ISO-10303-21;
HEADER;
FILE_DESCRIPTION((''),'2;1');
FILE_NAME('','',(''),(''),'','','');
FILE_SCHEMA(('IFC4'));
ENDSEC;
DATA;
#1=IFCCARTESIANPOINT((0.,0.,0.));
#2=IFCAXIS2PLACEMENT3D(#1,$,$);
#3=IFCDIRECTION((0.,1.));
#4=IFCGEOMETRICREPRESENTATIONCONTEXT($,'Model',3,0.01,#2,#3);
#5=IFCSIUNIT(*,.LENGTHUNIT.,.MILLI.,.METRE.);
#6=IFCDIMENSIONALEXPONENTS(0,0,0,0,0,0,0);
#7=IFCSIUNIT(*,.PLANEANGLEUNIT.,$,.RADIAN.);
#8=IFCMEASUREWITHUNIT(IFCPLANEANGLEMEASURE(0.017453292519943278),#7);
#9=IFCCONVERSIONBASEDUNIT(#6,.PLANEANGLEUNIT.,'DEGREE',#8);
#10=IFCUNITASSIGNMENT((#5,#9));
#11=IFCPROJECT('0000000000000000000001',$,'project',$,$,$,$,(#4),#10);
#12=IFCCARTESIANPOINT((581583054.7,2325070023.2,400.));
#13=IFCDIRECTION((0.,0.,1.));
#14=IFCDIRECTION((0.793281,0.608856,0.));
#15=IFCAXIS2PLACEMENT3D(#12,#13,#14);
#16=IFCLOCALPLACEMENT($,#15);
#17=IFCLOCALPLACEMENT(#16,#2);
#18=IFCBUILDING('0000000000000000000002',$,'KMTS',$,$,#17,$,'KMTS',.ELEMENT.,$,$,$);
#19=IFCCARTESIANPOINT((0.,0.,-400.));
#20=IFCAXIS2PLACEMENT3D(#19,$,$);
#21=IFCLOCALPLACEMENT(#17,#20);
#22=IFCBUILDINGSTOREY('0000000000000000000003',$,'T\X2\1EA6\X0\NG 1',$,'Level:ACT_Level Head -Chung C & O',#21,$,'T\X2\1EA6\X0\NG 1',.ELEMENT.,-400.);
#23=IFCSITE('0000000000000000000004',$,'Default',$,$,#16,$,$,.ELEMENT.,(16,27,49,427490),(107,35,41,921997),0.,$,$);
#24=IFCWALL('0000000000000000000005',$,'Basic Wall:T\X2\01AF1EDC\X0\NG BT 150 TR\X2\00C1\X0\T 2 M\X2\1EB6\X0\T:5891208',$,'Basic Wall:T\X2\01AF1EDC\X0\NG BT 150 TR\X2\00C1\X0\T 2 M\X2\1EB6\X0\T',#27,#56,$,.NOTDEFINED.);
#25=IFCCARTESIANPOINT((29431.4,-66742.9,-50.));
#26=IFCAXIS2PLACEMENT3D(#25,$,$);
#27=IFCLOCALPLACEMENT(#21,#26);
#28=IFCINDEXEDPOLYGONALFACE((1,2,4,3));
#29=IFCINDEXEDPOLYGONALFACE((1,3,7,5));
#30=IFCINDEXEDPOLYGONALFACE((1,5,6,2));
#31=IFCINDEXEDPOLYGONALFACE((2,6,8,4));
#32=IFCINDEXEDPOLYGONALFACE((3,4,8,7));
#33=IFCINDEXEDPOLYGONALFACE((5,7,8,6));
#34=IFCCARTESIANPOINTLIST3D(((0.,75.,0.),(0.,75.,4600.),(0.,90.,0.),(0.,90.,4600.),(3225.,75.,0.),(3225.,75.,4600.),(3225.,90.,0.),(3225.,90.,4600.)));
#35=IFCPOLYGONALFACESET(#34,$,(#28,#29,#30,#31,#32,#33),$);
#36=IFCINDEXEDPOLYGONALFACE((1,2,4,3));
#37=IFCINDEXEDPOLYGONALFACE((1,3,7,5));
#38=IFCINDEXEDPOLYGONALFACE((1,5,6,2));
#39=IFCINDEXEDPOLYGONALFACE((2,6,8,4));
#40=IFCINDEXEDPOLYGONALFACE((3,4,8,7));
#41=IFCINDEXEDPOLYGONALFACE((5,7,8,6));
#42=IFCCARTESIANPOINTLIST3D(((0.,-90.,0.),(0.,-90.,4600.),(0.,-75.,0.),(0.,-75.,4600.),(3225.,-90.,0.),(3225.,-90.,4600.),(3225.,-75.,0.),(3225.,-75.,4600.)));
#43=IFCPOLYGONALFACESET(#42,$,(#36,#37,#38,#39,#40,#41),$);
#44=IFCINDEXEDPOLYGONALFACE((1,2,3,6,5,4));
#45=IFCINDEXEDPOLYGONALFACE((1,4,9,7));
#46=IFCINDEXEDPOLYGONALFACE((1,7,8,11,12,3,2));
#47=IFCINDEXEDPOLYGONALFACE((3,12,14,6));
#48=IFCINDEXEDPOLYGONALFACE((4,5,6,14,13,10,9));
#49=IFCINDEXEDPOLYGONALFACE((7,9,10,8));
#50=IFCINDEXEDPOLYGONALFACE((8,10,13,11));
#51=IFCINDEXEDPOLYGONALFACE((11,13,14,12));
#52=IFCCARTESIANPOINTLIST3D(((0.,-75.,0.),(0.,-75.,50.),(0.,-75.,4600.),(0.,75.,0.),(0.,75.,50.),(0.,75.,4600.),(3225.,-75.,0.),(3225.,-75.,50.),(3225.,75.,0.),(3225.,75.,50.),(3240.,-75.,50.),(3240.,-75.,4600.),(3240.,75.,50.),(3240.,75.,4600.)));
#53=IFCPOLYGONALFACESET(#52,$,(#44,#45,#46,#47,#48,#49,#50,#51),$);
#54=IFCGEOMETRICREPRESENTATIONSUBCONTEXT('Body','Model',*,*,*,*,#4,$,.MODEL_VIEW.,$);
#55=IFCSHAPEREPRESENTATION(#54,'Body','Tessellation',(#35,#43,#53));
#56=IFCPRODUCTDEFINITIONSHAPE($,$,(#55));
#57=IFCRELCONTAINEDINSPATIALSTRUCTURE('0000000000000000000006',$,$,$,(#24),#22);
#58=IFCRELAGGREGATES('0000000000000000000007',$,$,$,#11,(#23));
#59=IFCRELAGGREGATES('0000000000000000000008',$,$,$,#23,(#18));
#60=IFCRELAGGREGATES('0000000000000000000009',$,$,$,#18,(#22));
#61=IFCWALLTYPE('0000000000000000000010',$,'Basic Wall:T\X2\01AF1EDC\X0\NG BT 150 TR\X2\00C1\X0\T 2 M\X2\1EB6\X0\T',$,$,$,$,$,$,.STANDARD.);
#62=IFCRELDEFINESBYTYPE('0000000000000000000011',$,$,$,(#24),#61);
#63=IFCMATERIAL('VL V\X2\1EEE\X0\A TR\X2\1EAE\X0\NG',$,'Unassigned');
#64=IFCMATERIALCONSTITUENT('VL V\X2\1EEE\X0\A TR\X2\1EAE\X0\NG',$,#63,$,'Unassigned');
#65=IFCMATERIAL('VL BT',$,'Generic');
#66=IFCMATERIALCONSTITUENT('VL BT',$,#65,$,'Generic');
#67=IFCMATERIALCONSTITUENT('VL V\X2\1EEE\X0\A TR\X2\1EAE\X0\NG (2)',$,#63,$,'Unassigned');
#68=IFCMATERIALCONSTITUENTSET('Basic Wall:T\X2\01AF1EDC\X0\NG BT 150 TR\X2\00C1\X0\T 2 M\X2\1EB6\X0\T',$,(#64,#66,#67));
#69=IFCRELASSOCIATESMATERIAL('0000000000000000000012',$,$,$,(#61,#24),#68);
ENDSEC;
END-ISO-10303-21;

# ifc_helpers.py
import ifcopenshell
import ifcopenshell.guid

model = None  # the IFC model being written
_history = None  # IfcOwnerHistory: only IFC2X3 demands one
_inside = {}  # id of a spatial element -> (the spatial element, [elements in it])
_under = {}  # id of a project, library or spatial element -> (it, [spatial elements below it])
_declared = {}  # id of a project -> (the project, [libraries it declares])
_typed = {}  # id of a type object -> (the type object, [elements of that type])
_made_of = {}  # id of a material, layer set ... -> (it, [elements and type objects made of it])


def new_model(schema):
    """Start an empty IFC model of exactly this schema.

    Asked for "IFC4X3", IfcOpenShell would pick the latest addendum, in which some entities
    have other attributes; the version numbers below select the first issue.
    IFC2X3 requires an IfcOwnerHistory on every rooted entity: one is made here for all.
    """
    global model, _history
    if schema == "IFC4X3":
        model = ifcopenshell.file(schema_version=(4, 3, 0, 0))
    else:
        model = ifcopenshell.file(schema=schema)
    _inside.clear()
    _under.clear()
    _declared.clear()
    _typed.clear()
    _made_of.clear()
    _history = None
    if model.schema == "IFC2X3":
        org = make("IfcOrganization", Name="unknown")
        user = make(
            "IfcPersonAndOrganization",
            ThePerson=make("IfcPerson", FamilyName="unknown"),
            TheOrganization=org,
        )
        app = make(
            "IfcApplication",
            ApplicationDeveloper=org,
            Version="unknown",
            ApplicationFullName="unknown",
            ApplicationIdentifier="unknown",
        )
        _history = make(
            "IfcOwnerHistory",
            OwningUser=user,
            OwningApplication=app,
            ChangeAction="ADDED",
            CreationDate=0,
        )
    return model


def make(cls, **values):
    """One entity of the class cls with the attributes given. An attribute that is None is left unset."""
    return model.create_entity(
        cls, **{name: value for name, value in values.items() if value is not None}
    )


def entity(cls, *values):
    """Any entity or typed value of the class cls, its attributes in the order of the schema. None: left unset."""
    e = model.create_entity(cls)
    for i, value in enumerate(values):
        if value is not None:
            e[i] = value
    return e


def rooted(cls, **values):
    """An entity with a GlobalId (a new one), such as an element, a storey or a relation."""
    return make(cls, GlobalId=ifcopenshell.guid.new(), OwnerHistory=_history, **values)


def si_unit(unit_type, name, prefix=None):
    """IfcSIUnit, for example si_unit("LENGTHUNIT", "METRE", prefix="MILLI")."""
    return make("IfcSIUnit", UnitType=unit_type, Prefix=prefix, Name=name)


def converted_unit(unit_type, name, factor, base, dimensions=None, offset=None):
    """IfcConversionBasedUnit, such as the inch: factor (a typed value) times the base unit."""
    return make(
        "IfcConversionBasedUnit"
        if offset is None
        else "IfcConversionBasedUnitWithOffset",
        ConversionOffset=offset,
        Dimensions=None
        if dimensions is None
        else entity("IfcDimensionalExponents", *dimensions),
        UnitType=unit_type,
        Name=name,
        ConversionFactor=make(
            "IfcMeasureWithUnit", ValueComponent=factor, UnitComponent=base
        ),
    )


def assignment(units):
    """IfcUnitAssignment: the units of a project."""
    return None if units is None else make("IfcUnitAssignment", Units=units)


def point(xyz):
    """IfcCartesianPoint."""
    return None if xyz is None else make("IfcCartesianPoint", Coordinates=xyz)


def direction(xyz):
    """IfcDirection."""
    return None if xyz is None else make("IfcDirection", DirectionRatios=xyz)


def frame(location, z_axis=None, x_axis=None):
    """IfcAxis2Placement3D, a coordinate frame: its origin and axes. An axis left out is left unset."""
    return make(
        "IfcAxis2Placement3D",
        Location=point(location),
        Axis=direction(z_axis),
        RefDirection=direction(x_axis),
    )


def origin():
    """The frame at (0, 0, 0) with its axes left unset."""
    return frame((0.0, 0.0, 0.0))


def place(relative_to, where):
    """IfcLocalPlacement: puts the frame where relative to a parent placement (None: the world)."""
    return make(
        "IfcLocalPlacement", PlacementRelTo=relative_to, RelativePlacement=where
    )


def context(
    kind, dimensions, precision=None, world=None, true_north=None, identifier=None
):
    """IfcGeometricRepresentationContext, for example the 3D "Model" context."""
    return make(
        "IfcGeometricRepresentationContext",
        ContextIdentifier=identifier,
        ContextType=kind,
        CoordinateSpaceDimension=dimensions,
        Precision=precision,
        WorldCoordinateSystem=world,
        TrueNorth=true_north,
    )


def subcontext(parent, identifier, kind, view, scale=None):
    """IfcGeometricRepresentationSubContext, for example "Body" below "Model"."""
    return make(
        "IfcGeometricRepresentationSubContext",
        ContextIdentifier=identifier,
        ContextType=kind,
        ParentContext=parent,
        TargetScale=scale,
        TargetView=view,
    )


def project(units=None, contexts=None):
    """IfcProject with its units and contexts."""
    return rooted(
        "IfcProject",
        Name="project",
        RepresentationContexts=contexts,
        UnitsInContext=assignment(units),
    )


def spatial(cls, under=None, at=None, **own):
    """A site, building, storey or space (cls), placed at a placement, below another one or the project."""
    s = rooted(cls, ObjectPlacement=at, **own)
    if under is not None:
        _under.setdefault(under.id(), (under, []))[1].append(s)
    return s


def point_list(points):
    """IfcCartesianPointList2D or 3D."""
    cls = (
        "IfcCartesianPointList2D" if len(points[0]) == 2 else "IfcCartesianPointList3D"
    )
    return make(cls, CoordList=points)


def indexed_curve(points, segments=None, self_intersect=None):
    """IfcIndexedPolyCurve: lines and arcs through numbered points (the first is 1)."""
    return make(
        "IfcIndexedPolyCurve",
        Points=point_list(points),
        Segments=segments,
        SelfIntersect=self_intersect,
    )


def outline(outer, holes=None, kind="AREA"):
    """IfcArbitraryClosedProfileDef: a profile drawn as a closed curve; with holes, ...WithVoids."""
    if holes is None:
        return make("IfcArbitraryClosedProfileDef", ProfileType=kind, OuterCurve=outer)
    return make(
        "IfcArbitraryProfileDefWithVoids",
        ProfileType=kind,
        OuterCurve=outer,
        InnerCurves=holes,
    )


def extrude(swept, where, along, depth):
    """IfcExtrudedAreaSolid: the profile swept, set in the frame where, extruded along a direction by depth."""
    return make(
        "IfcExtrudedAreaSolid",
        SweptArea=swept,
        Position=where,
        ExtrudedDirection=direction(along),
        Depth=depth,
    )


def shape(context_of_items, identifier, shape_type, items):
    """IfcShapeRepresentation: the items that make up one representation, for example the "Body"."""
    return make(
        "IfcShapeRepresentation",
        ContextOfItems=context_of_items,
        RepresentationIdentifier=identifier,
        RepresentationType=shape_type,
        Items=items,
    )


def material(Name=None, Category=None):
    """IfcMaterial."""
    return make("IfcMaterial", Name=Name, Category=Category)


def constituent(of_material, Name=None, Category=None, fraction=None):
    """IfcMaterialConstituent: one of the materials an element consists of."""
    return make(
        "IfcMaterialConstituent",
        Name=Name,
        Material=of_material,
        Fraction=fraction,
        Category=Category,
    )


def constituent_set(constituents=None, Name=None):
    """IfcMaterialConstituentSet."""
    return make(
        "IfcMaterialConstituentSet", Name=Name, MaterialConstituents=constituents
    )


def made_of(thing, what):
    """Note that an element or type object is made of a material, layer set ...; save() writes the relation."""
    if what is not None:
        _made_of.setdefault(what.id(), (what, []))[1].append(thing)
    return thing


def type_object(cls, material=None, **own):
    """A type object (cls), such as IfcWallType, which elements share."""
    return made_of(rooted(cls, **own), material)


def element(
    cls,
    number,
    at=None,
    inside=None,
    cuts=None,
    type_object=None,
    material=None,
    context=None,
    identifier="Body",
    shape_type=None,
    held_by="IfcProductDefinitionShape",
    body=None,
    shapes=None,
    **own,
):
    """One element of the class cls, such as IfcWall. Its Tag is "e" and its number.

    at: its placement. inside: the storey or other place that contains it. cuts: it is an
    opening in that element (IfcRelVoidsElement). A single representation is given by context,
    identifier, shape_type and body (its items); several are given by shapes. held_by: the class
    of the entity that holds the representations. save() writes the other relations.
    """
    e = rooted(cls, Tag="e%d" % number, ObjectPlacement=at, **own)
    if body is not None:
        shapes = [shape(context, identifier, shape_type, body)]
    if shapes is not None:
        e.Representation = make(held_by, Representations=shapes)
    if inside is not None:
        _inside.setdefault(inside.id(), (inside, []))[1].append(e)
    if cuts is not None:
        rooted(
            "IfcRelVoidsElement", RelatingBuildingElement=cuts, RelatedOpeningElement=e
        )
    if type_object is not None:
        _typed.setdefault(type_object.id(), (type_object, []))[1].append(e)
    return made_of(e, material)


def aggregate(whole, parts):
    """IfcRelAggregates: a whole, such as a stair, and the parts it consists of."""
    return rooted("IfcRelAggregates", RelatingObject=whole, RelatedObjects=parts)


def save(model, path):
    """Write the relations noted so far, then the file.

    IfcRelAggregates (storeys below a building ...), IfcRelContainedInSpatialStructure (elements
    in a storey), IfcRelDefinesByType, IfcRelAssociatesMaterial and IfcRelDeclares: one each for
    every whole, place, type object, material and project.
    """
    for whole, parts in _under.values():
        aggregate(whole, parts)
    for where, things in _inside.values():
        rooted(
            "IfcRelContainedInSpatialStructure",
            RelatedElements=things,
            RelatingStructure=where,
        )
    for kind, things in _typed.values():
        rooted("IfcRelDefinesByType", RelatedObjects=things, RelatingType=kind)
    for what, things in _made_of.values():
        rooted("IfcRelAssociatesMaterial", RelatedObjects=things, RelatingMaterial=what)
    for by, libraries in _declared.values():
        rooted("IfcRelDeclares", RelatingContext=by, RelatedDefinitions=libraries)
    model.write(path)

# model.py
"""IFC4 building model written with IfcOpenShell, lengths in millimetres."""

from ifc_helpers import new_model, entity, si_unit, converted_unit, direction, frame, origin, place, context, subcontext, project, spatial, indexed_curve, outline, extrude, material, constituent, constituent_set, type_object, element, save


model = new_model("IFC4")

# Units and contexts
model_context = context("Model", 3, precision=0.01, world=origin(), true_north=direction((0.0, 1.0)))
body_context = subcontext(model_context, "Body", "Model", "MODEL_VIEW")
ifc_project = project(units=[si_unit("LENGTHUNIT", "METRE", prefix="MILLI"), converted_unit("PLANEANGLEUNIT", "DEGREE", entity("IfcPlaneAngleMeasure", 0.017453292519943278), si_unit("PLANEANGLEUNIT", "RADIAN"), dimensions=[0, 0, 0, 0, 0, 0, 0])], contexts=[model_context])

# Site, building, storey
site_placement = place(None, frame((581583054.7, 2325070023.2, 400.0), z_axis=(0.0, 0.0, 1.0), x_axis=(0.793281, 0.608856, 0.0)))
site = spatial("IfcSite", under=ifc_project, at=site_placement, Name="Default", CompositionType="ELEMENT", RefLatitude=(16, 27, 49, 427490), RefLongitude=(107, 35, 41, 921997), RefElevation=0.0)
building_placement = place(site_placement, origin())
building = spatial("IfcBuilding", under=site, at=building_placement, Name="KMTS", LongName="KMTS", CompositionType="ELEMENT")
storey_placement = place(building_placement, frame((0.0, 0.0, -400.0)))
storey = spatial("IfcBuildingStorey", under=building, at=storey_placement, Name="TẦNG 1", ObjectType="Level:ACT_Level Head -Chung C & O", LongName="TẦNG 1", CompositionType="ELEMENT", Elevation=-400.0)

# Wall
ifc_material_1 = material(Name="VL VỮA TRẮNG", Category="Unassigned")
ifc_constituent_1 = constituent(ifc_material_1, Name="VL VỮA TRẮNG", Category="Unassigned")
ifc_material_2 = material(Name="VL BT", Category="Generic")
ifc_constituent_2 = constituent(ifc_material_2, Name="VL BT", Category="Generic")
ifc_constituent_3 = constituent(ifc_material_1, Name="VL VỮA TRẮNG (2)", Category="Unassigned")
ifc_constituent_set_1 = constituent_set(constituents=[ifc_constituent_1, ifc_constituent_2, ifc_constituent_3], Name="Basic Wall:TƯỜNG BT 150 TRÁT 2 MẶT")
wall_type_1 = type_object("IfcWallType", Name="Basic Wall:TƯỜNG BT 150 TRÁT 2 MẶT", PredefinedType="STANDARD", material=ifc_constituent_set_1)
wall_1_placement = place(storey_placement, frame((29431.4, -66742.9, -50.0)))
element("IfcWall", 1, at=wall_1_placement, inside=storey, type_object=wall_type_1, material=ifc_constituent_set_1, Name="Basic Wall:TƯỜNG BT 150 TRÁT 2 MẶT:5891208", ObjectType="Basic Wall:TƯỜNG BT 150 TRÁT 2 MẶT", PredefinedType="NOTDEFINED", context=body_context, shape_type="SweptSolid", body=[
    extrude(outline(indexed_curve([(-7.5, -1612.5), (7.5, -1612.5), (7.5, 1612.5), (-7.5, 1612.5), (-7.5, -1612.5)], self_intersect=False)), frame((1612.5, 82.5, 0.0), z_axis=(0.0, 0.0, 1.0), x_axis=(0.0, -1.0, 0.0)), (0.0, 0.0, 1.0), 4600.0),
    extrude(outline(indexed_curve([(-7.5, -1612.5), (7.5, -1612.5), (7.5, 1612.5), (-7.5, 1612.5), (-7.5, -1612.5)], self_intersect=False)), frame((1612.5, -82.5, 0.0), z_axis=(0.0, 0.0, 1.0), x_axis=(0.0, 1.0, 0.0)), (0.0, 0.0, 1.0), 4600.0),
    extrude(outline(indexed_curve([(-1335.7, -1847.1), (-1285.7, -1847.1), (3264.3, -1847.1), (3264.3, 1392.9), (-1285.7, 1392.9), (-1285.7, 1377.9), (-1335.7, 1377.9), (-1335.7, -1847.1)], self_intersect=False)), frame((1847.1, -75.0, 1335.7), z_axis=(0.0, 1.0, 0.0), x_axis=(0.0, 0.0, 1.0)), (0.0, 0.0, 1.0), 150.0),
])

save(model, "model.ifc")
